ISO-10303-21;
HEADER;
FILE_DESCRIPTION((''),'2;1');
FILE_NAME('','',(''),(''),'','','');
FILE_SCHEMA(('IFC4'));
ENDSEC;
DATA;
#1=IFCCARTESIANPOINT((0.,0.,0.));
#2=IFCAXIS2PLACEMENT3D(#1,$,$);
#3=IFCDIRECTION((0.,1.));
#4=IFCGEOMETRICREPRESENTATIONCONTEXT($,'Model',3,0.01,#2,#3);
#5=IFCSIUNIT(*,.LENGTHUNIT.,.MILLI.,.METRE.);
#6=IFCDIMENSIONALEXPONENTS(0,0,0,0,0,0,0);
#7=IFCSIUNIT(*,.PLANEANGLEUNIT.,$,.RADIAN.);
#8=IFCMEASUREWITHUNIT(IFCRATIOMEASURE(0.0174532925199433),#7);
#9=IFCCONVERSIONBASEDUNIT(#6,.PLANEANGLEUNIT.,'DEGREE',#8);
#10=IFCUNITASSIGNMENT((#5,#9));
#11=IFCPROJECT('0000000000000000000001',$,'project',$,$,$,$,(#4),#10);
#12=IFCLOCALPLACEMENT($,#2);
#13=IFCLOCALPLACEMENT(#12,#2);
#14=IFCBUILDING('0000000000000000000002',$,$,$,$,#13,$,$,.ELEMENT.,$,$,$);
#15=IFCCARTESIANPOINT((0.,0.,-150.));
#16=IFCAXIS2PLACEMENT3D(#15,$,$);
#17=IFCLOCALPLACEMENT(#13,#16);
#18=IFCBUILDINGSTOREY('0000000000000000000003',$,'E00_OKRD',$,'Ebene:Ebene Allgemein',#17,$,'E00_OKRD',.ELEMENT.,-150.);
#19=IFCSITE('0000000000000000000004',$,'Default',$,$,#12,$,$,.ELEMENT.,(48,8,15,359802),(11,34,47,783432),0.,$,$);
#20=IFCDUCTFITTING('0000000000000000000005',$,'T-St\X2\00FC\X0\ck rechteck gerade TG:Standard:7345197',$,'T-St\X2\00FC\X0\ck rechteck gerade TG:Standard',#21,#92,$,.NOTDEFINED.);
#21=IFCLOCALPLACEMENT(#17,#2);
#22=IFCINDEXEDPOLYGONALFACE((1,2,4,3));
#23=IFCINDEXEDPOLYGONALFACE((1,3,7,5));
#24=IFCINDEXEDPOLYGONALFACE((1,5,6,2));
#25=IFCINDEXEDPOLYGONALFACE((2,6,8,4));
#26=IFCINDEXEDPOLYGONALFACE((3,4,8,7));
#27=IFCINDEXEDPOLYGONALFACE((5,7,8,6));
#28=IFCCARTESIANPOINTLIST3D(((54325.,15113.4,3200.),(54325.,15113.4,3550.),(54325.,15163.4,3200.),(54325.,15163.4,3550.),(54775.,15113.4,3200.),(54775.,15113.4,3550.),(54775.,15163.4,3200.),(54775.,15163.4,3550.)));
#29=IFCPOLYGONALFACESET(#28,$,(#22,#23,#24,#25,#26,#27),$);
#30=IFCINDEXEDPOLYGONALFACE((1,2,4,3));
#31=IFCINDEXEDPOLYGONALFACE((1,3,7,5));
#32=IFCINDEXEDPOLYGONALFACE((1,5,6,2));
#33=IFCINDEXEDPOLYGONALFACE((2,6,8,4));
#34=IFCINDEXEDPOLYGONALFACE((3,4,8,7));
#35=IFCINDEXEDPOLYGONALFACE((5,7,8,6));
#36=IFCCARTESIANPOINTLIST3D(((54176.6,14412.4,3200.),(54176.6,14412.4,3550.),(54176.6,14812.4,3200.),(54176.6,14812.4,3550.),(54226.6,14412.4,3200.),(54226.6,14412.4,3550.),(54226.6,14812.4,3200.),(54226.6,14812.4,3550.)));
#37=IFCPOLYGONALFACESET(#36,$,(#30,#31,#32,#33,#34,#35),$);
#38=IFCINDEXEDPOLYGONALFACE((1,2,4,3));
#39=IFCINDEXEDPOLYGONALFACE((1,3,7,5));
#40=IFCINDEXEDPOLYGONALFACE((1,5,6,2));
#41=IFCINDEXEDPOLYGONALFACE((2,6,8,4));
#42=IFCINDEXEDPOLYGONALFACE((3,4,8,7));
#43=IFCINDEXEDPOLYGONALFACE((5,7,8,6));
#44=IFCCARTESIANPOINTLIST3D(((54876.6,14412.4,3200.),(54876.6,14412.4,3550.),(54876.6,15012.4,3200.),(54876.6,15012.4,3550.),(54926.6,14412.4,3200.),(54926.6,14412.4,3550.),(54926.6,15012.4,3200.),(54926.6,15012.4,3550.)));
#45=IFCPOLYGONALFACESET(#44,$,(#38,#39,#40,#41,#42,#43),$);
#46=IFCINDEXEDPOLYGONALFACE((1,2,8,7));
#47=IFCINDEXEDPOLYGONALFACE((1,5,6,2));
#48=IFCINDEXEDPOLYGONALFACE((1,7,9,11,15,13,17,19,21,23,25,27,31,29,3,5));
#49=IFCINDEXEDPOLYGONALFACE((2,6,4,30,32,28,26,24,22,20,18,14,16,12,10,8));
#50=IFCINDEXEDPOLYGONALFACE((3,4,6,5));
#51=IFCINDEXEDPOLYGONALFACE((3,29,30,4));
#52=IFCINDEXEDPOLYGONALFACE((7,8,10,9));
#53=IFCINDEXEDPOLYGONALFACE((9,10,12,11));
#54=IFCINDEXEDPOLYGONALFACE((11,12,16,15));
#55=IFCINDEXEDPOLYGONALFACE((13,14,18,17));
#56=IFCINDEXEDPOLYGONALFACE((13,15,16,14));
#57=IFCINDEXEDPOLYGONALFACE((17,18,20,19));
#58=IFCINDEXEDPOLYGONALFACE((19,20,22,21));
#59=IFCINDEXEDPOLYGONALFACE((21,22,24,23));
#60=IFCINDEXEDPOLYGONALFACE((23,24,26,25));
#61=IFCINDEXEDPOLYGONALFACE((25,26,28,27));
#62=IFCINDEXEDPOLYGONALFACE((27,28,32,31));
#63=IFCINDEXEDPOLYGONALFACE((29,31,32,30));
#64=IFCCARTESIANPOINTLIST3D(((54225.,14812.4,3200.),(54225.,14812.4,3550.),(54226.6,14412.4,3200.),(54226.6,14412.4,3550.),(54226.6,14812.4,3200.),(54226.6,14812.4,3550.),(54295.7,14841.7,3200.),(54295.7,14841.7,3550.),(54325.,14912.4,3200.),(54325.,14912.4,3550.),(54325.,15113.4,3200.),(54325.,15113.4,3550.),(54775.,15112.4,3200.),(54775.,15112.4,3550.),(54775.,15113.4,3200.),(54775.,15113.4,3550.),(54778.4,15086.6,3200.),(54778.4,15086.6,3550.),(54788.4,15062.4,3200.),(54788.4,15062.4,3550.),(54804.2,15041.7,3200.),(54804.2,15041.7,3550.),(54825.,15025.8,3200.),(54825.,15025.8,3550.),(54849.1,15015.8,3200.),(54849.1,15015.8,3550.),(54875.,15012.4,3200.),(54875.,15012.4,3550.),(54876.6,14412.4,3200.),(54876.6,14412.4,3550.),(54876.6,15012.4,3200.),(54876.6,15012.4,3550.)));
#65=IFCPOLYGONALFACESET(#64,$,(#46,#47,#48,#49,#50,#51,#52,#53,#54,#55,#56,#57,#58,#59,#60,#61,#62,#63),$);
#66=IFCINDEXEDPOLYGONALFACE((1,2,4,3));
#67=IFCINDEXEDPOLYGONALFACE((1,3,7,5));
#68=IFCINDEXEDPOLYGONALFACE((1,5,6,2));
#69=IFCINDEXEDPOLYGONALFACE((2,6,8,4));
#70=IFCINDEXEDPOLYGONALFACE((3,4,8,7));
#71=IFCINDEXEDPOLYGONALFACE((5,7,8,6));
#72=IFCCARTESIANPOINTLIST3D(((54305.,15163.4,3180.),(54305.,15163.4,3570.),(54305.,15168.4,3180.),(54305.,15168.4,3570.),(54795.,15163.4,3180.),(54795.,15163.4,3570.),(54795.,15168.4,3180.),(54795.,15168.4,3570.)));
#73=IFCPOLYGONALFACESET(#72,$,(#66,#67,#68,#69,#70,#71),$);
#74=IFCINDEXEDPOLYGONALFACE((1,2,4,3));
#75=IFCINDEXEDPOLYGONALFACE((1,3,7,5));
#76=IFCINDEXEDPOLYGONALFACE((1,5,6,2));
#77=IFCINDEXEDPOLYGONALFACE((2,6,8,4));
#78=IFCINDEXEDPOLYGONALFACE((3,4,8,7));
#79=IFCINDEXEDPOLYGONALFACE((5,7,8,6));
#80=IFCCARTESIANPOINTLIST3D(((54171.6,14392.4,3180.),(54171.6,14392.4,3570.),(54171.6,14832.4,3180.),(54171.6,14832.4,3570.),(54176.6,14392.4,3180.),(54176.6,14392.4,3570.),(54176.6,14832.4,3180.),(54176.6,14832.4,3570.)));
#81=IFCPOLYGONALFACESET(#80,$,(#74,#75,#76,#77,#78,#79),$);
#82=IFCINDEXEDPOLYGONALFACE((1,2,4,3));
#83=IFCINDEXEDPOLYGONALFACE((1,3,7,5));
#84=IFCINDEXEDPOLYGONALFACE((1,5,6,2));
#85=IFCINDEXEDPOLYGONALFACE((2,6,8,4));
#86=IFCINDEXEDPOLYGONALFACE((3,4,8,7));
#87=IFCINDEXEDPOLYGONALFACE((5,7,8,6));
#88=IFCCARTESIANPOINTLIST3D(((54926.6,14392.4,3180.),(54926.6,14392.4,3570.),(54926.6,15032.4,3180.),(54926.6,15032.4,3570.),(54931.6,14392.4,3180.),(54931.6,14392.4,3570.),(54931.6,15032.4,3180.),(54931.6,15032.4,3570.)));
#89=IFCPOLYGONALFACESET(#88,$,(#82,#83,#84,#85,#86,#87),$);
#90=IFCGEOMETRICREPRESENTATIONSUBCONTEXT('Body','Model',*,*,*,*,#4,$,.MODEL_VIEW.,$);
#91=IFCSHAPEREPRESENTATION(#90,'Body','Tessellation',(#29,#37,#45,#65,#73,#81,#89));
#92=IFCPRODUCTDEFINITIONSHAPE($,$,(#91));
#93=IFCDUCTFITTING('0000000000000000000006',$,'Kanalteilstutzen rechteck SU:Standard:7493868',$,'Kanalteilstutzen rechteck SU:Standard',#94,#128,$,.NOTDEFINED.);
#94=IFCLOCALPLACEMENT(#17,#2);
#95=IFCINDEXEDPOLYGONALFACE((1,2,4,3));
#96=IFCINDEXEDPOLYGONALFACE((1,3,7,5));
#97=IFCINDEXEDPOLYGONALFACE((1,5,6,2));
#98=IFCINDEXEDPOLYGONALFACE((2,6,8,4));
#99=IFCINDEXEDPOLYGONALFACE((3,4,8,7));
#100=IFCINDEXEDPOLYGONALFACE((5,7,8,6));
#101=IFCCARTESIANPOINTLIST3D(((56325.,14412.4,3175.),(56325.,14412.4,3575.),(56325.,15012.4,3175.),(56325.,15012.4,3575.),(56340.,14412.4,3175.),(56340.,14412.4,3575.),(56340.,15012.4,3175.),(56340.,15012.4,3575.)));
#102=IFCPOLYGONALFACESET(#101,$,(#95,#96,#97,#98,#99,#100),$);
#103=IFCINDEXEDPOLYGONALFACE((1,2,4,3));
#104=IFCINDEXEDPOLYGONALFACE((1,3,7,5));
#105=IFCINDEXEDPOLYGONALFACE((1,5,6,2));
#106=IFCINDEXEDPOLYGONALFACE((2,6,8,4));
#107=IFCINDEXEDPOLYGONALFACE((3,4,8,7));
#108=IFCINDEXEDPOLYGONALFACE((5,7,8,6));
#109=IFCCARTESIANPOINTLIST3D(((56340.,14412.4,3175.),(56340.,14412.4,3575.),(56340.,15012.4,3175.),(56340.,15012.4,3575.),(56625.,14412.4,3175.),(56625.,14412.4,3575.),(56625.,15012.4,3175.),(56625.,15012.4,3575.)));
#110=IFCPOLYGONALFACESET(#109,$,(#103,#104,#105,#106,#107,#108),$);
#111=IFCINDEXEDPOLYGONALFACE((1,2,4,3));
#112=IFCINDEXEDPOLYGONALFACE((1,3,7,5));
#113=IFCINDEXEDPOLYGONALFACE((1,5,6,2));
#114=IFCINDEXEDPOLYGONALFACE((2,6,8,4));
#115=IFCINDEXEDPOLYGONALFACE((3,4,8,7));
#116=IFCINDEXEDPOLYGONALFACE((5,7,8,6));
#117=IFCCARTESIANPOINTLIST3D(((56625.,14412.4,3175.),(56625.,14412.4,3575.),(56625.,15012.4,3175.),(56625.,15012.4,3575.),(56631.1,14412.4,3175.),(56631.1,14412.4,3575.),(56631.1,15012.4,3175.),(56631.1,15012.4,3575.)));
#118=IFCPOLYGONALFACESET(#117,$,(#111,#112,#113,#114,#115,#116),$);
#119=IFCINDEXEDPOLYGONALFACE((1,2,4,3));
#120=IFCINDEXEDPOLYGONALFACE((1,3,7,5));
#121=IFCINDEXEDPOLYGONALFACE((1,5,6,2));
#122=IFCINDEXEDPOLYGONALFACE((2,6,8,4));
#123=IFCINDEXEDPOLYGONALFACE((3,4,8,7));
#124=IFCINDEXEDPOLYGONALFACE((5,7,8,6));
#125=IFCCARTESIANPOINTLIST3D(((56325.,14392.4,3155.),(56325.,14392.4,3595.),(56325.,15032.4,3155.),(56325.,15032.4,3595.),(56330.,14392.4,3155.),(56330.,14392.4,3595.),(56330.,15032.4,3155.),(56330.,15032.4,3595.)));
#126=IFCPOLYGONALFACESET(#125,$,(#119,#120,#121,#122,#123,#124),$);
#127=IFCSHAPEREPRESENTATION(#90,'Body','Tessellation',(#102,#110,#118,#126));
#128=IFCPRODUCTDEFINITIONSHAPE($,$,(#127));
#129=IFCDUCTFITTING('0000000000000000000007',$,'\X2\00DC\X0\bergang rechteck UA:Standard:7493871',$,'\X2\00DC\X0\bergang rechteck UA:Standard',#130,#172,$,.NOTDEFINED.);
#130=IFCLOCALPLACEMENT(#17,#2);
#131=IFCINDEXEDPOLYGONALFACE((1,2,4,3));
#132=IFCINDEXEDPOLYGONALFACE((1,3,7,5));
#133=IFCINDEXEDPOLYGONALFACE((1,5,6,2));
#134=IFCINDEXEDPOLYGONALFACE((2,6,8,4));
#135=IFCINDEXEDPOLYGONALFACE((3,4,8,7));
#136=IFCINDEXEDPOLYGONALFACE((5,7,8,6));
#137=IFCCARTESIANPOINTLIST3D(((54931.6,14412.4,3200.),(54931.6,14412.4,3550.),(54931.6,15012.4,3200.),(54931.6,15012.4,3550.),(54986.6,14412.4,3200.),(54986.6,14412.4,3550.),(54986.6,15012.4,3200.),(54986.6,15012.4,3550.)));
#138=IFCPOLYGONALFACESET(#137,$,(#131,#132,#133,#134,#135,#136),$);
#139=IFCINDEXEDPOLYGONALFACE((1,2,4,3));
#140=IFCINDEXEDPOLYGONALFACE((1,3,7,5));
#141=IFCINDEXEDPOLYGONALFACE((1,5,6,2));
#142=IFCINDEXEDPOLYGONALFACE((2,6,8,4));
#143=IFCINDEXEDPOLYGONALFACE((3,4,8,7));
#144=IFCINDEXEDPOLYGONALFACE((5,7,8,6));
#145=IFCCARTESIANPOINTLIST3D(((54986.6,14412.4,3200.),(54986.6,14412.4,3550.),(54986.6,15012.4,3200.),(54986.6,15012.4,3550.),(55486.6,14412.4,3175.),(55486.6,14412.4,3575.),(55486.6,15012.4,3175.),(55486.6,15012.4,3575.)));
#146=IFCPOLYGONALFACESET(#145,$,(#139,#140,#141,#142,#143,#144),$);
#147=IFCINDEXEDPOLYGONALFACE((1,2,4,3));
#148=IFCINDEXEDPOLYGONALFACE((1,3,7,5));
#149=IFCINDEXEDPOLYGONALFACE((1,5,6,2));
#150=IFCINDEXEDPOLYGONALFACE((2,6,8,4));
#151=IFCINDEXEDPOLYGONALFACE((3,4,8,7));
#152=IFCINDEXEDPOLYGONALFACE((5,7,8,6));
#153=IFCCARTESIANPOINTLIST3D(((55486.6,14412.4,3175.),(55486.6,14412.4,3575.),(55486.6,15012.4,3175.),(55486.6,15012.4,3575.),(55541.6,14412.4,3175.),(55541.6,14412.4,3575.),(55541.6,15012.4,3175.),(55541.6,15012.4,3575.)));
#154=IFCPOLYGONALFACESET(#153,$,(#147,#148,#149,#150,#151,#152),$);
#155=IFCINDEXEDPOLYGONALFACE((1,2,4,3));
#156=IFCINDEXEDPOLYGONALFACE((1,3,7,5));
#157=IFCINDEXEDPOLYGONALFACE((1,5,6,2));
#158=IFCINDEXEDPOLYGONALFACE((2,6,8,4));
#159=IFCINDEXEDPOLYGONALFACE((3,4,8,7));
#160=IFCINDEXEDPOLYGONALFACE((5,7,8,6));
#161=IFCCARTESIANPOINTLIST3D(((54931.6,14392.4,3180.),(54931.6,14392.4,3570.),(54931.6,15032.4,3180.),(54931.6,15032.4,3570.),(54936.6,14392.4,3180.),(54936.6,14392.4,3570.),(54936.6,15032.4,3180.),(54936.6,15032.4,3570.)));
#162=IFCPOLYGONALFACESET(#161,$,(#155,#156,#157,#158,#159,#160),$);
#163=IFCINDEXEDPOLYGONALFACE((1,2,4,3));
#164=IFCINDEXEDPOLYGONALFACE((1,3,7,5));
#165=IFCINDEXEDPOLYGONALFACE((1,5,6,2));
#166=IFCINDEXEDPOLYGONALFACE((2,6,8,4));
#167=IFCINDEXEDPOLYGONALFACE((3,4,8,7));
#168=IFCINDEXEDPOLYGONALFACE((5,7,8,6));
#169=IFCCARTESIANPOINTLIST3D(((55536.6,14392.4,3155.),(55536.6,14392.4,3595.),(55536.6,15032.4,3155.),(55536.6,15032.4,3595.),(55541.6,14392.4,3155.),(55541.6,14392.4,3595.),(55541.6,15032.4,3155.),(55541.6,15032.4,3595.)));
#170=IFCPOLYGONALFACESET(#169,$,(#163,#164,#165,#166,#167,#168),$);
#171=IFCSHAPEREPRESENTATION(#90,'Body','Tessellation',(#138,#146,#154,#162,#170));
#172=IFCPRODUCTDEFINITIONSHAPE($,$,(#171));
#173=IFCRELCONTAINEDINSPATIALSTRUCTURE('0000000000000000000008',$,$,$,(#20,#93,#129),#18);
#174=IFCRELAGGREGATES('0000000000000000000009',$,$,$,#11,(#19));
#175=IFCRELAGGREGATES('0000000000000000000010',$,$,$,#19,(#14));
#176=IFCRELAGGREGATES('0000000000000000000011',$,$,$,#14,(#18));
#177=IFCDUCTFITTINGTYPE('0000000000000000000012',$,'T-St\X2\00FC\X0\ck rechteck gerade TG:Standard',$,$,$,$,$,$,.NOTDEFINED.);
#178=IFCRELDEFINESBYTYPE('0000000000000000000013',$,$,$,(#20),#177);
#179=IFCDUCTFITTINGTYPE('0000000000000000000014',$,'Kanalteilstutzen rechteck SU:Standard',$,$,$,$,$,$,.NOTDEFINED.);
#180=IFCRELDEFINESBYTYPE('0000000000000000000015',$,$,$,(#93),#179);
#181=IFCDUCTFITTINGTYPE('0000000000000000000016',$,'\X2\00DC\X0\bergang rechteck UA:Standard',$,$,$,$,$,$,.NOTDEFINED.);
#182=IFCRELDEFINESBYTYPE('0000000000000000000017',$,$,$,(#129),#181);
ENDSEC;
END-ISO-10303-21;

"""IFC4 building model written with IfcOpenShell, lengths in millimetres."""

from ifc_helpers import new_model, entity, si_unit, converted_unit, direction, frame, frame_2d, origin, origin_2d_with_axis, place, context, subcontext, project, spatial, polyline, circle_curve, parameter, trimmed, segment, composite_curve, rectangle, outline, extrude, source, transform, mapped, type_object, type_shapes, element, save


model = new_model("IFC4")

# Units and contexts
model_context = context("Model", 3, precision=0.01, world=origin(), true_north=direction((0.0, 1.0)))
body_context = subcontext(model_context, "Body", "Model", "MODEL_VIEW")
ifc_project = project(units=[si_unit("LENGTHUNIT", "METRE", prefix="MILLI"), converted_unit("PLANEANGLEUNIT", "DEGREE", entity("IfcRatioMeasure", 0.0174532925199433), si_unit("PLANEANGLEUNIT", "RADIAN"), dimensions=[0, 0, 0, 0, 0, 0, 0])], contexts=[model_context])

# Site, building, storey
site_placement = place(None, origin())
site = spatial("IfcSite", under=ifc_project, at=site_placement, Name="Default", CompositionType="ELEMENT", RefLatitude=(48, 8, 15, 359802), RefLongitude=(11, 34, 47, 783432), RefElevation=0.0)
building_placement = place(site_placement, origin())
building = spatial("IfcBuilding", under=site, at=building_placement, CompositionType="ELEMENT")
storey_placement = place(building_placement, frame((0.0, 0.0, -150.0)))
storey = spatial("IfcBuildingStorey", under=building, at=storey_placement, Name="E00_OKRD", ObjectType="Ebene:Ebene Allgemein", LongName="E00_OKRD", CompositionType="ELEMENT", Elevation=-150.0)

# Duct fittings
duct_fitting_type_1 = type_object("IfcDuctFittingType", Name="T-Stück rechteck gerade TG:Standard", PredefinedType="NOTDEFINED")
shared_shape_1 = source(origin(), body_context, "Body", "SweptSolid", [
    extrude(rectangle(XDim=50.0, YDim=450.0, at=frame_2d((0.0, 0.0), x_axis=(1.0, 0.0))), frame((0.0, -476.0, -175.0), z_axis=(0.0, 0.0, 1.0), x_axis=(0.0, -1.0, 0.0)), (0.0, 0.0, 1.0), 350.0),
    extrude(rectangle(XDim=50.0, YDim=400.0, at=origin_2d_with_axis()), frame((348.4, 50.0, -175.0), z_axis=(0.0, 0.0, 1.0), x_axis=(-1.0, 0.0, 0.0)), (0.0, 0.0, 1.0), 350.0),
    extrude(rectangle(XDim=50.0, YDim=600.0, at=origin_2d_with_axis()), frame((-351.6, -50.0, -175.0)), (0.0, 0.0, 1.0), 350.0),
    extrude(outline(composite_curve([segment(trimmed(circle_curve(frame_2d((-325.6, -39.8), x_axis=(-1.0, 0.0)), 100.0), [parameter(180.0)], [parameter(270.0)], True, "PARAMETER"), False, "CONTINUOUS"), segment(polyline([(-225.6, -39.8), (-225.6, -240.8)]), True, "CONTINUOUS"), segment(polyline([(-225.6, -240.8), (224.4, -240.8)]), True, "CONTINUOUS"), segment(polyline([(224.4, -240.8), (224.4, -239.8)]), True, "CONTINUOUS"), segment(trimmed(circle_curve(frame_2d((324.4, -239.8), x_axis=(-1.0, 0.0)), 100.0), [parameter(270.0)], [parameter(0.0)], True, "PARAMETER"), False, "CONTINUOUS"), segment(polyline([(324.4, -139.8), (326.0, -139.8)]), True, "CONTINUOUS"), segment(polyline([(326.0, -139.8), (326.0, 460.2)]), True, "CONTINUOUS"), segment(polyline([(326.0, 460.2), (-324.0, 460.2)]), True, "CONTINUOUS"), segment(polyline([(-324.0, 460.2), (-324.0, 60.2)]), True, "CONTINUOUS"), segment(polyline([(-324.0, 60.2), (-325.6, 60.2)]), True, "CONTINUOUS")], self_intersect=False)), frame((-0.6, -210.2, -175.0), z_axis=(0.0, 0.0, -1.0), x_axis=(-1.0, 0.0, 0.0)), (0.0, 0.0, -1.0), 350.0),
    extrude(rectangle(XDim=5.0, YDim=490.0, at=origin_2d_with_axis()), frame((0.0, -503.5, -195.0), z_axis=(0.0, 0.0, 1.0), x_axis=(0.0, 1.0, 0.0)), (0.0, 0.0, 1.0), 390.0),
    extrude(rectangle(XDim=5.0, YDim=440.0, at=origin_2d_with_axis()), frame((375.9, 50.0, -195.0), z_axis=(0.0, 0.0, 1.0), x_axis=(-1.0, 0.0, 0.0)), (0.0, 0.0, 1.0), 390.0),
    extrude(rectangle(XDim=5.0, YDim=640.0, at=origin_2d_with_axis()), frame((-379.1, -50.0, -195.0), z_axis=(0.0, 0.0, 1.0), x_axis=(-1.0, 0.0, 0.0)), (0.0, 0.0, 1.0), 390.0),
])
type_shapes(duct_fitting_type_1, [shared_shape_1])
duct_fitting_1_placement = place(storey_placement, frame((54550.0, 14662.4, 3375.0), z_axis=(0.0, 0.0, 1.0), x_axis=(-1.0, 0.0, 0.0)))
element("IfcDuctFitting", 1, at=duct_fitting_1_placement, inside=storey, type_object=duct_fitting_type_1, Name="T-Stück rechteck gerade TG:Standard:7345197", ObjectType="T-Stück rechteck gerade TG:Standard", PredefinedType="NOTDEFINED", context=body_context, shape_type="MappedRepresentation", body=[
    mapped(shared_shape_1, transform((0.0, 0.0, 0.0), scale=1.0)),
])
duct_fitting_type_2 = type_object("IfcDuctFittingType", Name="Kanalteilstutzen rechteck SU:Standard", PredefinedType="NOTDEFINED")
shared_shape_2 = source(origin(), body_context, "Body", "SweptSolid", [
    extrude(rectangle(XDim=15.0, YDim=400.0, at=frame_2d((0.0, 0.0), x_axis=(1.0, 0.0))), frame((292.5, 0.0, -300.0)), (0.0, 0.0, 1.0), 600.0),
    extrude(rectangle(XDim=285.0, YDim=400.0, at=frame_2d((0.0, 0.0), x_axis=(1.0, 0.0))), frame((142.5, 0.0, -300.0)), (0.0, 0.0, 1.0), 600.0),
    extrude(rectangle(XDim=6.1, YDim=400.0, at=frame_2d((0.0, 0.0), x_axis=(1.0, 0.0))), frame((-3.0, 0.0, -300.0)), (0.0, 0.0, 1.0), 600.0),
    extrude(rectangle(XDim=5.0, YDim=440.0, at=frame_2d((0.0, 0.0), x_axis=(1.0, 0.0))), frame((297.5, 0.0, -320.0)), (0.0, 0.0, 1.0), 640.0),
])
type_shapes(duct_fitting_type_2, [shared_shape_2])
duct_fitting_2_placement = place(storey_placement, frame((56625.0, 14712.4, 3375.0), z_axis=(0.0, 1.0, 0.0), x_axis=(-1.0, 0.0, 0.0)))
element("IfcDuctFitting", 2, at=duct_fitting_2_placement, inside=storey, type_object=duct_fitting_type_2, Name="Kanalteilstutzen rechteck SU:Standard:7493868", ObjectType="Kanalteilstutzen rechteck SU:Standard", PredefinedType="NOTDEFINED", context=body_context, shape_type="MappedRepresentation", body=[
    mapped(shared_shape_2, transform((0.0, 0.0, 0.0), scale=1.0)),
])
duct_fitting_type_3 = type_object("IfcDuctFittingType", Name="Übergang rechteck UA:Standard", PredefinedType="NOTDEFINED")
shared_shape_3 = source(origin(), body_context, "Body", "SweptSolid", [
    extrude(rectangle(XDim=55.0, YDim=600.0, at=frame_2d((0.0, 0.0), x_axis=(1.0, 0.0))), frame((582.5, 0.0, -175.0)), (0.0, 0.0, 1.0), 350.0),
    extrude(outline(polyline([(-259.7, -187.3), (240.9, -187.3), (258.4, 162.3), (-239.7, 212.2), (-259.7, -187.3)])), frame((305.0, -300.0, 0.0), z_axis=(0.0, 1.0, 0.0), x_axis=(0.998752, 0.0, -0.049938)), (0.0, 0.0, 1.0), 600.0),
    extrude(rectangle(XDim=55.0, YDim=600.0, at=frame_2d((0.0, 0.0), x_axis=(1.0, 0.0))), frame((27.5, 0.0, -200.0)), (0.0, 0.0, 1.0), 400.0),
    extrude(rectangle(XDim=5.0, YDim=640.0, at=frame_2d((0.0, 0.0), x_axis=(1.0, 0.0))), frame((607.5, 0.0, -195.0)), (0.0, 0.0, 1.0), 390.0),
    extrude(rectangle(XDim=5.0, YDim=640.0, at=frame_2d((0.0, 0.0), x_axis=(1.0, 0.0))), frame((2.5, 0.0, -220.0)), (0.0, 0.0, 1.0), 440.0),
])
type_shapes(duct_fitting_type_3, [shared_shape_3])
duct_fitting_3_placement = place(storey_placement, frame((55541.6, 14712.4, 3375.0), z_axis=(0.0, 0.0, 1.0), x_axis=(-1.0, 0.0, 0.0)))
element("IfcDuctFitting", 3, at=duct_fitting_3_placement, inside=storey, type_object=duct_fitting_type_3, Name="Übergang rechteck UA:Standard:7493871", ObjectType="Übergang rechteck UA:Standard", PredefinedType="NOTDEFINED", context=body_context, shape_type="MappedRepresentation", body=[
    mapped(shared_shape_3, transform((0.0, 0.0, 0.0), scale=1.0)),
])

save(model, "model.ifc")
